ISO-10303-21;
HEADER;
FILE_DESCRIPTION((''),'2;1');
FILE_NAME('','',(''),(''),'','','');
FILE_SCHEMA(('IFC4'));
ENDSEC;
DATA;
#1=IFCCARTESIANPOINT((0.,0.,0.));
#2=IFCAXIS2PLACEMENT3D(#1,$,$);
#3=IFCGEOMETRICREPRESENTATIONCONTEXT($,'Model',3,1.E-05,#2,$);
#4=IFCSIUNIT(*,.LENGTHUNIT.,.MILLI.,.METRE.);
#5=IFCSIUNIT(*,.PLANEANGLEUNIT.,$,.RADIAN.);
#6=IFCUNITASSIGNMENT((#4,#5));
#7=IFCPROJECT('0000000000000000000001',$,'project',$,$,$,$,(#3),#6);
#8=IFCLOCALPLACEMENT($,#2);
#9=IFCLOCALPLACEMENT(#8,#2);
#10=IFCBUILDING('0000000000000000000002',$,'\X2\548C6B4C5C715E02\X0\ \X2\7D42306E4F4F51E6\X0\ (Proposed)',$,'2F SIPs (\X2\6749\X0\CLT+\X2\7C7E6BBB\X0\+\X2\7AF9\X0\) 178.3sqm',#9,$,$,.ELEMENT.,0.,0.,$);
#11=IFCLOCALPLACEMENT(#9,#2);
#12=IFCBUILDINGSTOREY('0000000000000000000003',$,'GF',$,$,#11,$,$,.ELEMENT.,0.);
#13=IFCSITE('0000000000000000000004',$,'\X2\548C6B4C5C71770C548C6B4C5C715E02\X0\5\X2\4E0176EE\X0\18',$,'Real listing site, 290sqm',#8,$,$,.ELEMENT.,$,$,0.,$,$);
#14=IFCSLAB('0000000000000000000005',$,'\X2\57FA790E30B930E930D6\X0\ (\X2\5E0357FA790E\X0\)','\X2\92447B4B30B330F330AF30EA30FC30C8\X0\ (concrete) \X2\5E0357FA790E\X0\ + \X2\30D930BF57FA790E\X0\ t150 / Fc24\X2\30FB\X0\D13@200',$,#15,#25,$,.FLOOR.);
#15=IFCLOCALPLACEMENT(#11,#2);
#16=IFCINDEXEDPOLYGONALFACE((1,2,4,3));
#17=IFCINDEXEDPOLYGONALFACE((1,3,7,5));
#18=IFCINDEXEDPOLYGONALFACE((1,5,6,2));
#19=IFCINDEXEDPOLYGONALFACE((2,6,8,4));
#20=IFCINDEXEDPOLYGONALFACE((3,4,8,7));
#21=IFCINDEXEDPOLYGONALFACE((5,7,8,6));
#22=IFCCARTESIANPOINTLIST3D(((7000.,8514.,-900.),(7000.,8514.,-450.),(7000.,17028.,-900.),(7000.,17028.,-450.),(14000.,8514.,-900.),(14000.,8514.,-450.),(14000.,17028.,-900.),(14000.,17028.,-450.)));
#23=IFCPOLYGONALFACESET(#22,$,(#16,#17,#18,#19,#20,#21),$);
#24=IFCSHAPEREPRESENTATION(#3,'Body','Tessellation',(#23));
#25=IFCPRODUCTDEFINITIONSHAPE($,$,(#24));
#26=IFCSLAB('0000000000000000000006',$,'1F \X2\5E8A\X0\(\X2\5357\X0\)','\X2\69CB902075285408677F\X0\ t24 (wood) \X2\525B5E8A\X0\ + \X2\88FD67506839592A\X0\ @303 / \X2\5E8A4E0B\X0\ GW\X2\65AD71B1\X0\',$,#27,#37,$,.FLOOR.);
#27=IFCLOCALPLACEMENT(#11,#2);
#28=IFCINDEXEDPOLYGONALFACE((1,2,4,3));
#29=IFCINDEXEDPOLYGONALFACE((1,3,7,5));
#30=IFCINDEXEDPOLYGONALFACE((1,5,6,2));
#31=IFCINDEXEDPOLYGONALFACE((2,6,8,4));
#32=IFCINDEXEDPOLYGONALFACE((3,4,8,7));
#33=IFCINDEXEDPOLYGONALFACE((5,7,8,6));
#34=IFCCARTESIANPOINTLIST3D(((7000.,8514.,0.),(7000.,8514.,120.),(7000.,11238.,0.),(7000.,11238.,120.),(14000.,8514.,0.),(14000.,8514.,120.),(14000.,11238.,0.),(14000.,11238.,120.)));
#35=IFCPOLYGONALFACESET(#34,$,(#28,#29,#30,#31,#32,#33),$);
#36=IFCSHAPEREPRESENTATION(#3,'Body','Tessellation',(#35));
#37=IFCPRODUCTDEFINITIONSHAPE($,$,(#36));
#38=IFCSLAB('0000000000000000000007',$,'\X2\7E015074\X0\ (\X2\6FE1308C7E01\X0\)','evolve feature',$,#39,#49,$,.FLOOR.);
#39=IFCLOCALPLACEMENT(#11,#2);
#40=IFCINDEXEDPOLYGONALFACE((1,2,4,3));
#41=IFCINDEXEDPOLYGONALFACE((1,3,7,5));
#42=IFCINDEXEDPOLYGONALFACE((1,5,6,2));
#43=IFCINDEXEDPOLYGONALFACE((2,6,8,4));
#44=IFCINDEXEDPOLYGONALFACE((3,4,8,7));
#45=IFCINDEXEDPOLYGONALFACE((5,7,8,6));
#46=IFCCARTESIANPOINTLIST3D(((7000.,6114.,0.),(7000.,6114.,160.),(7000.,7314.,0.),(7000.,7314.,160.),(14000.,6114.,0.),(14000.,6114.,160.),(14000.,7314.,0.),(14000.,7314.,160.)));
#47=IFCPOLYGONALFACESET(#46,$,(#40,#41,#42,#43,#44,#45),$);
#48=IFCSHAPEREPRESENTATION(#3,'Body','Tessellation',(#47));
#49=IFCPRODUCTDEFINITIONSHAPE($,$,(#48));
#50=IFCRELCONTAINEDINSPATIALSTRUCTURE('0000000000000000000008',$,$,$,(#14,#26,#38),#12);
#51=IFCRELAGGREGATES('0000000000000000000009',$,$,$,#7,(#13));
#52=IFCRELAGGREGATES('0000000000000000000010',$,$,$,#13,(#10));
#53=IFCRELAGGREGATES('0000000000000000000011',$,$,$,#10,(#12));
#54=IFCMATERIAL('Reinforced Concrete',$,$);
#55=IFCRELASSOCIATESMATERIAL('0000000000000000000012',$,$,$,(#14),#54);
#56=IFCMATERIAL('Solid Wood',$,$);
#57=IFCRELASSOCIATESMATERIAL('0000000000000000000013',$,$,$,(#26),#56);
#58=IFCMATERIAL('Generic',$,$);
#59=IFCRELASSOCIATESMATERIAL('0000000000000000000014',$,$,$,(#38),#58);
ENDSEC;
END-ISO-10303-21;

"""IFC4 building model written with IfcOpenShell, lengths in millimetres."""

from ifc_helpers import new_model, si_unit, frame, frame_2d, origin, place, context, project, spatial, rectangle, extrude, material, element, save


model = new_model("IFC4")

# Units and contexts
model_context = context("Model", 3, precision=1e-05, world=origin())
ifc_project = project(units=[si_unit("LENGTHUNIT", "METRE", prefix="MILLI"), si_unit("PLANEANGLEUNIT", "RADIAN")], contexts=[model_context])

# Site, building, storey
site_placement = place(None, origin())
site = spatial("IfcSite", under=ifc_project, at=site_placement, Name="和歌山県和歌山市5丁目18", ObjectType="Real listing site, 290sqm", CompositionType="ELEMENT", RefElevation=0.0)
building_placement = place(site_placement, origin())
building = spatial("IfcBuilding", under=site, at=building_placement, Name="和歌山市 終の住処 (Proposed)", ObjectType="2F SIPs (杉CLT+籾殻+竹) 178.3sqm", CompositionType="ELEMENT", ElevationOfRefHeight=0.0, ElevationOfTerrain=0.0)
storey_placement = place(building_placement, origin())
storey = spatial("IfcBuildingStorey", under=building, at=storey_placement, Name="GF", CompositionType="ELEMENT", Elevation=0.0)

# Slabs
ifc_material_1 = material(Name="Reinforced Concrete")
slab_1_placement = place(storey_placement, frame((3500.0, 4257.0, -450.0)))
element("IfcSlab", 1, at=slab_1_placement, inside=storey, material=ifc_material_1, Name="基礎スラブ (布基礎)", Description="鉄筋コンクリート (concrete) 布基礎 + ベタ基礎 t150 / Fc24・D13@200", PredefinedType="FLOOR", context=model_context, shape_type="SweptSolid", body=[
    extrude(rectangle(XDim=7000.0, YDim=8514.0, at=frame_2d((3500.0, 4257.0))), frame((3500.0, 4257.0, -450.0)), (0.0, 0.0, 1.0), 450.0),
])
ifc_material_2 = material(Name="Solid Wood")
slab_2_placement = place(storey_placement, frame((3500.0, 4257.0, 0.0)))
element("IfcSlab", 2, at=slab_2_placement, inside=storey, material=ifc_material_2, Name="1F 床(南)", Description="構造用合板 t24 (wood) 剛床 + 製材根太 @303 / 床下 GW断熱", PredefinedType="FLOOR", context=model_context, shape_type="SweptSolid", body=[
    extrude(rectangle(XDim=7000.0, YDim=2724.0, at=frame_2d((3500.0, 1362.0))), frame((3500.0, 4257.0, 0.0)), (0.0, 0.0, 1.0), 120.0),
])
ifc_material_3 = material(Name="Generic")
slab_3_placement = place(storey_placement, frame((3500.0, 3057.0, 0.0)))
element("IfcSlab", 3, at=slab_3_placement, inside=storey, material=ifc_material_3, Name="縁側 (濡れ縁)", Description="evolve feature", PredefinedType="FLOOR", context=model_context, shape_type="SweptSolid", body=[
    extrude(rectangle(XDim=7000.0, YDim=1200.0, at=frame_2d((3500.0, 600.0))), frame((3500.0, 3057.0, 0.0)), (0.0, 0.0, 1.0), 160.0),
])

save(model, "model.ifc")
